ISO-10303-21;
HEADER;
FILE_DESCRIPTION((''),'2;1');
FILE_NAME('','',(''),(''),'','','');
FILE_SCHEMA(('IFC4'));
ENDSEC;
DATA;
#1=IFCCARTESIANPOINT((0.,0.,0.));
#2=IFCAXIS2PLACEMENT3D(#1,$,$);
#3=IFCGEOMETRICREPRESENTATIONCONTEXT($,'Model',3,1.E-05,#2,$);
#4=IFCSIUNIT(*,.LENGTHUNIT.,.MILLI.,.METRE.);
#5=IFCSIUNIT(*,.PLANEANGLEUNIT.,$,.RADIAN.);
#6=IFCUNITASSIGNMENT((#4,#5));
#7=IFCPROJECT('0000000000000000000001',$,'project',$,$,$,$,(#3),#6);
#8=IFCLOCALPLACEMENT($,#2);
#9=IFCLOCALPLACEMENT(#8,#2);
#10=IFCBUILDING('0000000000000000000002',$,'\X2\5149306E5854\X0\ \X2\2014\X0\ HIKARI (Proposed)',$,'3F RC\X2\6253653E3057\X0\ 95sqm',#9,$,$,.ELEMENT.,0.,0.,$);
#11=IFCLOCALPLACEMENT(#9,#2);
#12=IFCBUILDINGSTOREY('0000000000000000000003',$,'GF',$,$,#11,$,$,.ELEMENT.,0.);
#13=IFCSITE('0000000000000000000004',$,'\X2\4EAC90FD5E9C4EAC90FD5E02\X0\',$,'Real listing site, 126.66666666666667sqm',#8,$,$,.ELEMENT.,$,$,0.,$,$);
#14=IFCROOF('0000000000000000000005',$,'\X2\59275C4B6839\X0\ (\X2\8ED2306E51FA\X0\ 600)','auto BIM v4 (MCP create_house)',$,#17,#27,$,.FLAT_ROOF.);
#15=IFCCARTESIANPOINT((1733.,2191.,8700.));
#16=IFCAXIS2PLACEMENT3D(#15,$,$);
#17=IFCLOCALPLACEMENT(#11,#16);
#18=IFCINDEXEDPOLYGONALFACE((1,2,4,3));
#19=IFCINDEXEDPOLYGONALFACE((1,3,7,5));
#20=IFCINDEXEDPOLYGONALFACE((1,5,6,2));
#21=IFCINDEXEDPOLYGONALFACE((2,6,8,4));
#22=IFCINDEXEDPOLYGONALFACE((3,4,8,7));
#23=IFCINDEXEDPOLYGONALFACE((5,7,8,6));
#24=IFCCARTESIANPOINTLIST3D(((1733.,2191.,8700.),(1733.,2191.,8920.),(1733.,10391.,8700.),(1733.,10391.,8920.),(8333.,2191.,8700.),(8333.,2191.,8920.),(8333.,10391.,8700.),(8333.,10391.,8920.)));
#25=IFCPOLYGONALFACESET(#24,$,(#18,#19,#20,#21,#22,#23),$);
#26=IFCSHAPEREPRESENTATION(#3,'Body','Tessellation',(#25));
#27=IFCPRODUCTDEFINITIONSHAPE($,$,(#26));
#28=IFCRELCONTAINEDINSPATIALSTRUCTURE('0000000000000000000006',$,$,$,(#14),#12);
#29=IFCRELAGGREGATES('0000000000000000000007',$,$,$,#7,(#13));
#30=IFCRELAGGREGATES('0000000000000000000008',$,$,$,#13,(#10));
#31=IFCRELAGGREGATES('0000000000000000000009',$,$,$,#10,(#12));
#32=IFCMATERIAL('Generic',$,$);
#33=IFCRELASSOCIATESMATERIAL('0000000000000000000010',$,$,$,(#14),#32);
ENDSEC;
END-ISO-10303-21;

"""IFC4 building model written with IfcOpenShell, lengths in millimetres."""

from ifc_helpers import new_model, si_unit, frame, frame_2d, origin, place, context, project, spatial, rectangle, extrude, material, element, save


model = new_model("IFC4")

# Units and contexts
model_context = context("Model", 3, precision=1e-05, world=origin())
ifc_project = project(units=[si_unit("LENGTHUNIT", "METRE", prefix="MILLI"), si_unit("PLANEANGLEUNIT", "RADIAN")], contexts=[model_context])

# Site, building, storey
site_placement = place(None, origin())
site = spatial("IfcSite", under=ifc_project, at=site_placement, Name="京都府京都市", ObjectType="Real listing site, 126.66666666666667sqm", CompositionType="ELEMENT", RefElevation=0.0)
building_placement = place(site_placement, origin())
building = spatial("IfcBuilding", under=site, at=building_placement, Name="光の塔 — HIKARI (Proposed)", ObjectType="3F RC打放し 95sqm", CompositionType="ELEMENT", ElevationOfRefHeight=0.0, ElevationOfTerrain=0.0)
storey_placement = place(building_placement, origin())
storey = spatial("IfcBuildingStorey", under=building, at=storey_placement, Name="GF", CompositionType="ELEMENT", Elevation=0.0)

# Shared definitions
ifc_material = material(Name="Generic")

# Roof
roof_placement = place(storey_placement, frame((1733.0, 2191.0, 8700.0)))
element("IfcRoof", 1, at=roof_placement, inside=storey, material=ifc_material, Name="大屋根 (軒の出 600)", Description="auto BIM v4 (MCP create_house)", PredefinedType="FLAT_ROOF", context=model_context, shape_type="SweptSolid", body=[
    extrude(rectangle(XDim=6600.0, YDim=8200.0, at=frame_2d((3300.0, 4100.0))), frame((1733.0, 2191.0, 8700.0)), (0.0, 0.0, 1.0), 220.0),
])

save(model, "model.ifc")
